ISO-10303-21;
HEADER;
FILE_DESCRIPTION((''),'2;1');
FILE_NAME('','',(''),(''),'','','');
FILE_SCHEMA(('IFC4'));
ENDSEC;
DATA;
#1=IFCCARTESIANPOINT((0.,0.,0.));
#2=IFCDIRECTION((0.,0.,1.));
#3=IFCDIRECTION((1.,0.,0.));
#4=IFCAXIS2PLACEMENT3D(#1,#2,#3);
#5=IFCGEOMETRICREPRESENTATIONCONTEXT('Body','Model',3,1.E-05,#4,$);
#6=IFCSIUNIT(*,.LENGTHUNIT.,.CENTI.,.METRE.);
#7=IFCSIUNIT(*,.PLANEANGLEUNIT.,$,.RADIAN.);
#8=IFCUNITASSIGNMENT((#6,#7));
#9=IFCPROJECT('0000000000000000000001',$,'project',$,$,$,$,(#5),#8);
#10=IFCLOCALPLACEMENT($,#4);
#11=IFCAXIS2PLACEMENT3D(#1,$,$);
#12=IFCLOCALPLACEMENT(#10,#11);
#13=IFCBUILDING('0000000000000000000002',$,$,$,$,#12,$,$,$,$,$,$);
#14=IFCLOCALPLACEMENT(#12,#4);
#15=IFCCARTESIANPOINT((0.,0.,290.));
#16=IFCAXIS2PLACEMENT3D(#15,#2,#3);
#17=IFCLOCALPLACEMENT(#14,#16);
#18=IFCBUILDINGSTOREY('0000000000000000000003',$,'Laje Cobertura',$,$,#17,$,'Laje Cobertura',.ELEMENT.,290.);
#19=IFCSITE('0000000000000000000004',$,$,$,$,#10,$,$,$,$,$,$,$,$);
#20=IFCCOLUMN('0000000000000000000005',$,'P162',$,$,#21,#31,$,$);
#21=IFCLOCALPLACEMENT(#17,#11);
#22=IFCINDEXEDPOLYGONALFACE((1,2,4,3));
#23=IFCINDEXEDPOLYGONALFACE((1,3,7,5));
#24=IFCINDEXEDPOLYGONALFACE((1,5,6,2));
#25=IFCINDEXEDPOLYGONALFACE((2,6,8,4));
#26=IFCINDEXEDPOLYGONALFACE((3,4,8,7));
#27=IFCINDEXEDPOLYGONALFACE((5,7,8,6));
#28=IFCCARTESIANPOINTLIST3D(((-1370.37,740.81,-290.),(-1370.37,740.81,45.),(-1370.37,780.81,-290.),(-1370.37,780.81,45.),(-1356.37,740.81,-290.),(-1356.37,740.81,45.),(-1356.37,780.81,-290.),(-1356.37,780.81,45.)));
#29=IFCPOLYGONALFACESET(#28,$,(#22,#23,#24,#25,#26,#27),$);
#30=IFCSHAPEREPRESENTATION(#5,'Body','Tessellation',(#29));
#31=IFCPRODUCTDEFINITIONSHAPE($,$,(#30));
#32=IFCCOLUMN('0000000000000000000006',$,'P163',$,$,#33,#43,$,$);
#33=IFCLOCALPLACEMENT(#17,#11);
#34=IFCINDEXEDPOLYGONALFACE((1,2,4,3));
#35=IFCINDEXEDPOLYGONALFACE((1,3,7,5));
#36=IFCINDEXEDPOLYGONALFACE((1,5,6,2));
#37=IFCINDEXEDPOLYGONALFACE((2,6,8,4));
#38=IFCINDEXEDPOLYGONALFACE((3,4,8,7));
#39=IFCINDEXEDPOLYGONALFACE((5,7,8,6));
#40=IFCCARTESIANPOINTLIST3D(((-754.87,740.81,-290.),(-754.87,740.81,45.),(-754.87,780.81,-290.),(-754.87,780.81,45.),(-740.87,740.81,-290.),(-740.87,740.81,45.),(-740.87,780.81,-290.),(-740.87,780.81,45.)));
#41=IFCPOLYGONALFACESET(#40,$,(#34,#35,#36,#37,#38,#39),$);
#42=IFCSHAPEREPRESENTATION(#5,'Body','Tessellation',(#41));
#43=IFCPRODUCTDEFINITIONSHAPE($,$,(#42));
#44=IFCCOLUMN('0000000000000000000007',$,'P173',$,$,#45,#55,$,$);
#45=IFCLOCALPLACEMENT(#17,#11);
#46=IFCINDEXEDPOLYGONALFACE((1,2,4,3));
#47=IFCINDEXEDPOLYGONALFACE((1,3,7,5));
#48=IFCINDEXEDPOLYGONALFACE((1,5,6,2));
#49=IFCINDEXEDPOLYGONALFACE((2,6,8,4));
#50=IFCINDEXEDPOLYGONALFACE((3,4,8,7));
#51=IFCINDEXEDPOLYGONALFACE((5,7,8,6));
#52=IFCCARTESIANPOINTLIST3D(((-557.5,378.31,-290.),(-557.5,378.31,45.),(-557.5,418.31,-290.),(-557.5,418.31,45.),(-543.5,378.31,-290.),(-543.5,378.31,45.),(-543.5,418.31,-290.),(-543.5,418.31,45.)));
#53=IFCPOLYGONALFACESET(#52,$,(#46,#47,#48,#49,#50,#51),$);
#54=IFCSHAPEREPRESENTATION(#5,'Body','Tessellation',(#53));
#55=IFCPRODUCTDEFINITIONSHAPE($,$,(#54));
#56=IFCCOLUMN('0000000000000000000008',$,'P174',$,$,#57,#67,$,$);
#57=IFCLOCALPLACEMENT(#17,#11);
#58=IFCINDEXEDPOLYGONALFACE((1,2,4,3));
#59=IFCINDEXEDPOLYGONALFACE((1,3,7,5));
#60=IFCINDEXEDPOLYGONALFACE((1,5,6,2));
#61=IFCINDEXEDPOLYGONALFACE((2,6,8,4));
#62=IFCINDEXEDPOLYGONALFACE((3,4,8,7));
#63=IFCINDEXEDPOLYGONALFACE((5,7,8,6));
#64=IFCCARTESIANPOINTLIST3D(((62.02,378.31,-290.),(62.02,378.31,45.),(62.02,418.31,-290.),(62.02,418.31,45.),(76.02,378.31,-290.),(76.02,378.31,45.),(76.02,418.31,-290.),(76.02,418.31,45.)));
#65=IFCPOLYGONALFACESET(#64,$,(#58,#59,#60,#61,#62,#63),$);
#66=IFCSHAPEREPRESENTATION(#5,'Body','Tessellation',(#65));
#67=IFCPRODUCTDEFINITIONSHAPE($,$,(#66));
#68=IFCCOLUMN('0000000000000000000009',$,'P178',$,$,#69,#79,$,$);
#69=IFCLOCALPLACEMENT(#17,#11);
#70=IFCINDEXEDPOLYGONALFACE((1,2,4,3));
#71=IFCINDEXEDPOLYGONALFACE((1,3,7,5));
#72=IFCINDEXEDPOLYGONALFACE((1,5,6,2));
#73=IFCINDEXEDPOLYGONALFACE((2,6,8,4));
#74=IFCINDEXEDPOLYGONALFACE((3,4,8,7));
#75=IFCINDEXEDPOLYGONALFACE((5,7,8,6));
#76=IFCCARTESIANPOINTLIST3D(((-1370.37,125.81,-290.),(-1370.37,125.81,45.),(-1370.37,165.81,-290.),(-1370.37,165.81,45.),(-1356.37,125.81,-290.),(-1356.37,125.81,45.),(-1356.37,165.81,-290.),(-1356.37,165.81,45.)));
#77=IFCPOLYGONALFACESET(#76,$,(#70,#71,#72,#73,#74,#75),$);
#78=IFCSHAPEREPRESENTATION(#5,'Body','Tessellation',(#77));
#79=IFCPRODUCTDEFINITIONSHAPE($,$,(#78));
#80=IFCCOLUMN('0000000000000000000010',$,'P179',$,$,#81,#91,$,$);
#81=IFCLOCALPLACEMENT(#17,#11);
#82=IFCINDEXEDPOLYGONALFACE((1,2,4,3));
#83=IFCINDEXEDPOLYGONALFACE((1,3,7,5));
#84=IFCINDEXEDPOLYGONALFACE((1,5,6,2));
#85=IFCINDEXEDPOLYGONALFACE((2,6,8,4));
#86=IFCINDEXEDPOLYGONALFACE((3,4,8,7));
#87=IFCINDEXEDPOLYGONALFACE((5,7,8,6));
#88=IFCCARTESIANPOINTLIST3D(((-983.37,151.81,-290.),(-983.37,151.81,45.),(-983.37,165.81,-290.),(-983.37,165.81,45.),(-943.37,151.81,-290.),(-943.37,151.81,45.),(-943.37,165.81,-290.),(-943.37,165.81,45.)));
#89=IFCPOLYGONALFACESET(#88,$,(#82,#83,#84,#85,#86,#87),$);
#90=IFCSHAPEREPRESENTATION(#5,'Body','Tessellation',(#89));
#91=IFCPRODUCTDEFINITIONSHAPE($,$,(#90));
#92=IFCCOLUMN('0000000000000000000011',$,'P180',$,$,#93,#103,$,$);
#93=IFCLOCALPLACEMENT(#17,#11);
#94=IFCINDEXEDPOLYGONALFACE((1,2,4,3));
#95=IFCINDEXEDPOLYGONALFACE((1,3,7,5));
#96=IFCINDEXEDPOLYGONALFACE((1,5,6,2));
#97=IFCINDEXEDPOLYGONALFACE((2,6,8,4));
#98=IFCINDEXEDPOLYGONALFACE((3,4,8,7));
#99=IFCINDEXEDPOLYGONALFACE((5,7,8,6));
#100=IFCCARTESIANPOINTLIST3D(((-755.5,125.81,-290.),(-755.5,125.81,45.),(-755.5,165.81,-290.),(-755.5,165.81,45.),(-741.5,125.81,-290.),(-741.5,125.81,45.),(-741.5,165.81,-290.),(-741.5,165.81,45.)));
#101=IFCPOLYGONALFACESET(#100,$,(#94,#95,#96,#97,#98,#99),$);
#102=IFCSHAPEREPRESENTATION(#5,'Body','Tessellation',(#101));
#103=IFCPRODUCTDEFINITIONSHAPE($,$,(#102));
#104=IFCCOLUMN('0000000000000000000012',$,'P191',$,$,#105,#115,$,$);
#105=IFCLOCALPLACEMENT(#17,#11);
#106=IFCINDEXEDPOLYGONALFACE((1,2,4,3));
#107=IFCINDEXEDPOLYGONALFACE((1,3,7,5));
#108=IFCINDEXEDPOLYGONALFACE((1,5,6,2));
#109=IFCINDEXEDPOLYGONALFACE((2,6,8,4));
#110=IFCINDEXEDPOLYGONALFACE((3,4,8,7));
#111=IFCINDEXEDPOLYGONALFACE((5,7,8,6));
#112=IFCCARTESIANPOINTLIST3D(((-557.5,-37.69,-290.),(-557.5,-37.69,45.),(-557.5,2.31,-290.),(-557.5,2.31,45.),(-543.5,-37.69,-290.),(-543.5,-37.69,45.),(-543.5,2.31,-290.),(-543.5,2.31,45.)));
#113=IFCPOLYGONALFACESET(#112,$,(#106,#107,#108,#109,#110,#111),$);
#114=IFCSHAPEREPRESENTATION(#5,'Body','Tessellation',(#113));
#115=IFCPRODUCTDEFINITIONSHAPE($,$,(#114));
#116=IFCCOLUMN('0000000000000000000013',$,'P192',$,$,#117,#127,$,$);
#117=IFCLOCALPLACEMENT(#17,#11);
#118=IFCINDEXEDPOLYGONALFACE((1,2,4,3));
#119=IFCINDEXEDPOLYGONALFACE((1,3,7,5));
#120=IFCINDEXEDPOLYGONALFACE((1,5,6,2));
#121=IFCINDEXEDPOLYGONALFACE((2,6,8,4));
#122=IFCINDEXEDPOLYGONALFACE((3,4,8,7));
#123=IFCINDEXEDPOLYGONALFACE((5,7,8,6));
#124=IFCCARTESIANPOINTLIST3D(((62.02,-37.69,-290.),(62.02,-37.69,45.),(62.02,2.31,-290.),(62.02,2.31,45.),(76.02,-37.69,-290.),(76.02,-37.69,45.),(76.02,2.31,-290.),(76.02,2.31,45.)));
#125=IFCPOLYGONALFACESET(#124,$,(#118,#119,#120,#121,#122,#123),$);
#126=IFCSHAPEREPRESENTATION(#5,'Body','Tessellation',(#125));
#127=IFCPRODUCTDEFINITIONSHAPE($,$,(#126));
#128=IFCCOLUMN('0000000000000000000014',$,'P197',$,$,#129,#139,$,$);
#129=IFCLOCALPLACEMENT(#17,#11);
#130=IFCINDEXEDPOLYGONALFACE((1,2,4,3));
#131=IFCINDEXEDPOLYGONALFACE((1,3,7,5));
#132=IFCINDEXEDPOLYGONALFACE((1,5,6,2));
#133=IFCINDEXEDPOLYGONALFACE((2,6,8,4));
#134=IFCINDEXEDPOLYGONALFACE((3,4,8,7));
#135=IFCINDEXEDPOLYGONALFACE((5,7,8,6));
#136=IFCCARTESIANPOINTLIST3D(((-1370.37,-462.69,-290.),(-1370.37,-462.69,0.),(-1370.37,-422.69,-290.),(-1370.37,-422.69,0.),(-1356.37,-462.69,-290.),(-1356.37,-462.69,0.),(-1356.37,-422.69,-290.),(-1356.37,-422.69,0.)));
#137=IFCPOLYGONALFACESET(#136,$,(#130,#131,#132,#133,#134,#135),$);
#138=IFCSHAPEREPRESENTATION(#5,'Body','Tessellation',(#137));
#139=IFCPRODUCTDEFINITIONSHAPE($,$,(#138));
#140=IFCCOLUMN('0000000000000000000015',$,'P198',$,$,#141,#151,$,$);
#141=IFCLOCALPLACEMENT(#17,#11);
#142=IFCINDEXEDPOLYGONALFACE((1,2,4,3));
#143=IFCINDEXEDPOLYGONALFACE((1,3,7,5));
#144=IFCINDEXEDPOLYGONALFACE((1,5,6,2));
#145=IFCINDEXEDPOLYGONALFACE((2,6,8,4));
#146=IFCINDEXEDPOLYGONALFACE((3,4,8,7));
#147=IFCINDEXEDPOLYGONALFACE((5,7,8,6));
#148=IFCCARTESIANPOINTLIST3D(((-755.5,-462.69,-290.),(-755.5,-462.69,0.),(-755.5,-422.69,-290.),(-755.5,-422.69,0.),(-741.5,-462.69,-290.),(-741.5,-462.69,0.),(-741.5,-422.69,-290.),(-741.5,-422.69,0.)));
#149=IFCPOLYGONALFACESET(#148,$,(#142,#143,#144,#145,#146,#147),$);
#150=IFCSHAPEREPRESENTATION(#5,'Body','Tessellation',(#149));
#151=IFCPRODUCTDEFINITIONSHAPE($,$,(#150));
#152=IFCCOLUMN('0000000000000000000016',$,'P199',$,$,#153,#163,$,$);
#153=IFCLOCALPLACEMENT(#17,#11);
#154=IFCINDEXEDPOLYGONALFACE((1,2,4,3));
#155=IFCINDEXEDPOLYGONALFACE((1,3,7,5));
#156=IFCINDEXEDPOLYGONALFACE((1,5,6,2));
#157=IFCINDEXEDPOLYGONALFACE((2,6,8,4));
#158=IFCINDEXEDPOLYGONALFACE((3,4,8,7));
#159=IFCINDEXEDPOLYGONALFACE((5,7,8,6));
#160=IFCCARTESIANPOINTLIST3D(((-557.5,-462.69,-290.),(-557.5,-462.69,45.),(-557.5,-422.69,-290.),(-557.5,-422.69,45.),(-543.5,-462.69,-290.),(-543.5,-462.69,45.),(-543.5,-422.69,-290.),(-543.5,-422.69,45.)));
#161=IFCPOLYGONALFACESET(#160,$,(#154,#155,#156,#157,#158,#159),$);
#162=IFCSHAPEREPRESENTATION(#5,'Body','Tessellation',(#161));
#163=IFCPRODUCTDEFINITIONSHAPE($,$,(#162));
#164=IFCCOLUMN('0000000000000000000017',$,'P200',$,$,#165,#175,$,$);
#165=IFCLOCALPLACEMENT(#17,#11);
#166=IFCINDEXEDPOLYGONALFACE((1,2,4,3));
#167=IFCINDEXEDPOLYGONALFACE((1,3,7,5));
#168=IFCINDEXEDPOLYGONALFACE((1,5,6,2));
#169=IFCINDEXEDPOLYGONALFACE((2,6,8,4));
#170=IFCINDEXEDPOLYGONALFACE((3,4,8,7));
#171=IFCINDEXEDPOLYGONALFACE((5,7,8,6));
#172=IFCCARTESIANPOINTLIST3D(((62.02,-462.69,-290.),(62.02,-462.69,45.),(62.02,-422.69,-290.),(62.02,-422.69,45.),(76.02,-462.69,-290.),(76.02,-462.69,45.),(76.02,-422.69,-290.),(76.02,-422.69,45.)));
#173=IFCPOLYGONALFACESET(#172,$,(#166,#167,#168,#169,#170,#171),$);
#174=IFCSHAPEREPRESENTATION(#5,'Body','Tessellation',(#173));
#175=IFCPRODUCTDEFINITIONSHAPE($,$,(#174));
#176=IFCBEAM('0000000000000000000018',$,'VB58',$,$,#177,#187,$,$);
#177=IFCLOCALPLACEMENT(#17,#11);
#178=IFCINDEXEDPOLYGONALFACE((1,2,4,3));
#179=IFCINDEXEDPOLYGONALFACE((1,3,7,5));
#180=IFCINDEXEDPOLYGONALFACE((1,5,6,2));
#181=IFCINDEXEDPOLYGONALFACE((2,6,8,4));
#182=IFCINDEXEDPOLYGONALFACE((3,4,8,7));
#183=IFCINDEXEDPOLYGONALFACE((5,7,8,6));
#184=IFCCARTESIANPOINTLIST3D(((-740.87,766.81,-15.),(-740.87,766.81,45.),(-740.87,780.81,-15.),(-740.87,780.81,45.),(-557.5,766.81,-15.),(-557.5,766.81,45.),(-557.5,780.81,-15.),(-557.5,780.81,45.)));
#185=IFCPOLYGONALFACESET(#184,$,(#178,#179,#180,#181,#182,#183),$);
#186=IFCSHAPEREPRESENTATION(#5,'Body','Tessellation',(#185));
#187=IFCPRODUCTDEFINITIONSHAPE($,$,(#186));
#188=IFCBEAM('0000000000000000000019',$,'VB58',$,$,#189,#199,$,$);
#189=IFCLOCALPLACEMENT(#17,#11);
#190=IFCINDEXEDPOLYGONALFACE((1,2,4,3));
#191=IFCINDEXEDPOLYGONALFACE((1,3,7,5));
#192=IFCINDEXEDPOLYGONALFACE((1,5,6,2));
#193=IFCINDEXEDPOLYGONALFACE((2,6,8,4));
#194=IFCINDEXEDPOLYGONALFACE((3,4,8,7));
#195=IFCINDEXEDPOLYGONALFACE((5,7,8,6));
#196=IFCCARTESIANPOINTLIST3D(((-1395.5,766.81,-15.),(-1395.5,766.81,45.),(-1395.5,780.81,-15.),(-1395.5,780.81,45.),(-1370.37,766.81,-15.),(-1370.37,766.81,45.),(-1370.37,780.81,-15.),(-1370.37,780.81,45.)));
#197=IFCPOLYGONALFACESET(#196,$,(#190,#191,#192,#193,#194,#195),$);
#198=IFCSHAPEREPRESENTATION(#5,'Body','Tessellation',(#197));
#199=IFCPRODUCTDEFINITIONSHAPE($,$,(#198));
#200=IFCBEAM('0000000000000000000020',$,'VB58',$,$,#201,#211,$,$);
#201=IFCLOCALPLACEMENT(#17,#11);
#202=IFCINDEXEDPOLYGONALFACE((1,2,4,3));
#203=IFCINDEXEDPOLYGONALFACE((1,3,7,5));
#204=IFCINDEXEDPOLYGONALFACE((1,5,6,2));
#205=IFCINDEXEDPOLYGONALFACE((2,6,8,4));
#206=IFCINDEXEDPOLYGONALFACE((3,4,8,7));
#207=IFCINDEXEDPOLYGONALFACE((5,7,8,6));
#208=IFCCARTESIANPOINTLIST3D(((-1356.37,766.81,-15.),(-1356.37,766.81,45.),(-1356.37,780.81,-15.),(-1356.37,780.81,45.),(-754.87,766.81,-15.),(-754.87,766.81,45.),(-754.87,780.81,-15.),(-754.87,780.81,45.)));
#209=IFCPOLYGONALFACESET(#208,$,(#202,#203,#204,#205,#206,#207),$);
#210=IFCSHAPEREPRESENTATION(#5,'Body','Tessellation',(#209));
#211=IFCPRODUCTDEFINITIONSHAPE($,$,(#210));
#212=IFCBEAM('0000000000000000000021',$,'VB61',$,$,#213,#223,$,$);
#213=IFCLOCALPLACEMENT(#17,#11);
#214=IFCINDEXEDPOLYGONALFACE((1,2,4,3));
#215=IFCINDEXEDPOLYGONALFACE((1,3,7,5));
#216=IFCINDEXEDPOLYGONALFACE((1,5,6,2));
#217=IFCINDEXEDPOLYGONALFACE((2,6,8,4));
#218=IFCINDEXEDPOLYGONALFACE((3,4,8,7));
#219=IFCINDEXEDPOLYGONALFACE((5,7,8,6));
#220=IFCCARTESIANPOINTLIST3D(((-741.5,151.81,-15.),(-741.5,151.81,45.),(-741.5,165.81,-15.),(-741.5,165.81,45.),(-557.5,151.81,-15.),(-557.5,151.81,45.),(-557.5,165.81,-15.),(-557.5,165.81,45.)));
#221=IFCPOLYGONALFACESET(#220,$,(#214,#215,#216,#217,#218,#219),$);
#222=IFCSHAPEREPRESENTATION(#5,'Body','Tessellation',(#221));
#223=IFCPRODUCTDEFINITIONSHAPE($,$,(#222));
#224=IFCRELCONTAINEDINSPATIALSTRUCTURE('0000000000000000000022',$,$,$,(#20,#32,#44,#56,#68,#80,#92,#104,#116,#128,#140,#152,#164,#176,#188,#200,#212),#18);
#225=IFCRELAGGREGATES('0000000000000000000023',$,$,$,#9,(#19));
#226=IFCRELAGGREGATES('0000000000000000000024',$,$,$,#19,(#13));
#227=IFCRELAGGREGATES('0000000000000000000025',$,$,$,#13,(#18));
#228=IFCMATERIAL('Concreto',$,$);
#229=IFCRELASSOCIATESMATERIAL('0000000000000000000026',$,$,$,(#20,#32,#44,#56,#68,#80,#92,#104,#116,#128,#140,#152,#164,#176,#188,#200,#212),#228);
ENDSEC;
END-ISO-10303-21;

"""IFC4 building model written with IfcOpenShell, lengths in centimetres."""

from ifc_helpers import new_model, si_unit, frame, origin, origin_with_axes, origin_2d_with_axis, place, context, project, spatial, rectangle, extrude, material, element, save


model = new_model("IFC4")

# Units and contexts
model_context = context("Model", 3, precision=1e-05, world=origin_with_axes(), identifier="Body")
ifc_project = project(units=[si_unit("LENGTHUNIT", "METRE", prefix="CENTI"), si_unit("PLANEANGLEUNIT", "RADIAN")], contexts=[model_context])

# Site, building, storey
site_placement = place(None, origin_with_axes())
site = spatial("IfcSite", under=ifc_project, at=site_placement)
building_placement = place(site_placement, origin())
building = spatial("IfcBuilding", under=site, at=building_placement)
placement = place(building_placement, origin_with_axes())
storey_placement = place(placement, frame((0.0, 0.0, 290.0), z_axis=(0.0, 0.0, 1.0), x_axis=(1.0, 0.0, 0.0)))
storey = spatial("IfcBuildingStorey", under=building, at=storey_placement, Name="Laje Cobertura", LongName="Laje Cobertura", CompositionType="ELEMENT", Elevation=290.0)

# Columns
ifc_material = material(Name="Concreto")
for number, where, z_axis, x_axis, name in (
    (1, (-1363.37, 760.81, 45.0), (0.0, 0.0, 1.0), (1.0, 0.0, 0.0), "P162"),
    (2, (-747.87, 760.81, 45.0), (0.0, 0.0, 1.0), (1.0, 0.0, 0.0), "P163"),
    (3, (-550.5, 398.31, 45.0), (0.0, 0.0, 1.0), (1.0, 0.0, 0.0), "P173"),
    (4, (69.02, 398.31, 45.0), (0.0, 0.0, 1.0), (1.0, 0.0, 0.0), "P174"),
    (5, (-1363.37, 145.81, 45.0), (0.0, 0.0, 1.0), (1.0, 0.0, 0.0), "P178"),
):
    element("IfcColumn", number, at=place(storey_placement, frame(where, z_axis=z_axis, x_axis=x_axis)), inside=storey, material=ifc_material, Name=name, context=model_context, shape_type="SolidModel", body=[
        extrude(rectangle(XDim=14.0, YDim=40.0, at=origin_2d_with_axis()), origin_with_axes(), (0.0, 0.0, -1.0), 335.0),
    ])
column_placement = place(storey_placement, frame((-963.37, 158.81, 45.0), z_axis=(0.0, 0.0, 1.0), x_axis=(1.0, 0.0, 0.0)))
element("IfcColumn", 6, at=column_placement, inside=storey, material=ifc_material, Name="P179", context=model_context, shape_type="SolidModel", body=[
    extrude(rectangle(XDim=14.0, YDim=40.0, at=origin_2d_with_axis()), frame((0.0, 0.0, 0.0), z_axis=(0.0, 0.0, 1.0), x_axis=(0.0, -1.0, 0.0)), (0.0, 0.0, -1.0), 335.0),
])
for number, where, z_axis, x_axis, name in (
    (7, (-748.5, 145.81, 45.0), (0.0, 0.0, 1.0), (1.0, 0.0, 0.0), "P180"),
    (8, (-550.5, -17.69, 45.0), (0.0, 0.0, 1.0), (1.0, 0.0, 0.0), "P191"),
    (9, (69.02, -17.69, 45.0), (0.0, 0.0, 1.0), (1.0, 0.0, 0.0), "P192"),
):
    element("IfcColumn", number, at=place(storey_placement, frame(where, z_axis=z_axis, x_axis=x_axis)), inside=storey, material=ifc_material, Name=name, context=model_context, shape_type="SolidModel", body=[
        extrude(rectangle(XDim=14.0, YDim=40.0, at=origin_2d_with_axis()), origin_with_axes(), (0.0, 0.0, -1.0), 335.0),
    ])
for number, where, z_axis, x_axis, name in (
    (10, (-1363.37, -442.69, 0.0), (0.0, 0.0, 1.0), (1.0, 0.0, 0.0), "P197"),
    (11, (-748.5, -442.69, 0.0), (0.0, 0.0, 1.0), (1.0, 0.0, 0.0), "P198"),
):
    element("IfcColumn", number, at=place(storey_placement, frame(where, z_axis=z_axis, x_axis=x_axis)), inside=storey, material=ifc_material, Name=name, context=model_context, shape_type="SolidModel", body=[
        extrude(rectangle(XDim=14.0, YDim=40.0, at=origin_2d_with_axis()), origin_with_axes(), (0.0, 0.0, -1.0), 290.0),
    ])
for number, where, z_axis, x_axis, name in (
    (12, (-550.5, -442.69, 45.0), (0.0, 0.0, 1.0), (1.0, 0.0, 0.0), "P199"),
    (13, (69.02, -442.69, 45.0), (0.0, 0.0, 1.0), (1.0, 0.0, 0.0), "P200"),
):
    element("IfcColumn", number, at=place(storey_placement, frame(where, z_axis=z_axis, x_axis=x_axis)), inside=storey, material=ifc_material, Name=name, context=model_context, shape_type="SolidModel", body=[
        extrude(rectangle(XDim=14.0, YDim=40.0, at=origin_2d_with_axis()), origin_with_axes(), (0.0, 0.0, -1.0), 335.0),
    ])

# Beams
beam_1_placement = place(storey_placement, frame((-649.18, 773.81, 45.0), z_axis=(0.0, 0.0, 1.0), x_axis=(1.0, 0.0, 0.0)))
element("IfcBeam", 14, at=beam_1_placement, inside=storey, material=ifc_material, Name="VB58", context=model_context, shape_type="SolidModel", body=[
    extrude(rectangle(XDim=14.0, YDim=60.0, at=origin_2d_with_axis()), frame((-91.69, 0.0, -30.0), z_axis=(1.0, 0.0, 0.0), x_axis=(0.0, 1.0, 0.0)), (0.0, 0.0, 1.0), 183.37),
])
beam_2_placement = place(storey_placement, frame((-1382.93, 773.81, 45.0), z_axis=(0.0, 0.0, 1.0), x_axis=(1.0, 0.0, 0.0)))
element("IfcBeam", 15, at=beam_2_placement, inside=storey, material=ifc_material, Name="VB58", context=model_context, shape_type="SolidModel", body=[
    extrude(rectangle(XDim=14.0, YDim=60.0, at=origin_2d_with_axis()), frame((-12.56, 0.0, -30.0), z_axis=(1.0, 0.0, 0.0), x_axis=(0.0, -1.0, 0.0)), (0.0, 0.0, 1.0), 25.13),
])
beam_3_placement = place(storey_placement, frame((-1055.62, 773.81, 45.0), z_axis=(0.0, 0.0, 1.0), x_axis=(1.0, 0.0, 0.0)))
element("IfcBeam", 16, at=beam_3_placement, inside=storey, material=ifc_material, Name="VB58", context=model_context, shape_type="SolidModel", body=[
    extrude(rectangle(XDim=14.0, YDim=60.0, at=origin_2d_with_axis()), frame((-300.75, 0.0, -30.0), z_axis=(1.0, 0.0, 0.0), x_axis=(0.0, -1.0, 0.0)), (0.0, 0.0, 1.0), 601.5),
])
beam_4_placement = place(storey_placement, frame((-649.5, 158.81, 45.0), z_axis=(0.0, 0.0, 1.0), x_axis=(1.0, 0.0, 0.0)))
element("IfcBeam", 17, at=beam_4_placement, inside=storey, material=ifc_material, Name="VB61", context=model_context, shape_type="SolidModel", body=[
    extrude(rectangle(XDim=14.0, YDim=60.0, at=origin_2d_with_axis()), frame((-92.0, 0.0, -30.0), z_axis=(1.0, 0.0, 0.0), x_axis=(0.0, -1.0, 0.0)), (0.0, 0.0, 1.0), 184.0),
])

save(model, "model.ifc")
